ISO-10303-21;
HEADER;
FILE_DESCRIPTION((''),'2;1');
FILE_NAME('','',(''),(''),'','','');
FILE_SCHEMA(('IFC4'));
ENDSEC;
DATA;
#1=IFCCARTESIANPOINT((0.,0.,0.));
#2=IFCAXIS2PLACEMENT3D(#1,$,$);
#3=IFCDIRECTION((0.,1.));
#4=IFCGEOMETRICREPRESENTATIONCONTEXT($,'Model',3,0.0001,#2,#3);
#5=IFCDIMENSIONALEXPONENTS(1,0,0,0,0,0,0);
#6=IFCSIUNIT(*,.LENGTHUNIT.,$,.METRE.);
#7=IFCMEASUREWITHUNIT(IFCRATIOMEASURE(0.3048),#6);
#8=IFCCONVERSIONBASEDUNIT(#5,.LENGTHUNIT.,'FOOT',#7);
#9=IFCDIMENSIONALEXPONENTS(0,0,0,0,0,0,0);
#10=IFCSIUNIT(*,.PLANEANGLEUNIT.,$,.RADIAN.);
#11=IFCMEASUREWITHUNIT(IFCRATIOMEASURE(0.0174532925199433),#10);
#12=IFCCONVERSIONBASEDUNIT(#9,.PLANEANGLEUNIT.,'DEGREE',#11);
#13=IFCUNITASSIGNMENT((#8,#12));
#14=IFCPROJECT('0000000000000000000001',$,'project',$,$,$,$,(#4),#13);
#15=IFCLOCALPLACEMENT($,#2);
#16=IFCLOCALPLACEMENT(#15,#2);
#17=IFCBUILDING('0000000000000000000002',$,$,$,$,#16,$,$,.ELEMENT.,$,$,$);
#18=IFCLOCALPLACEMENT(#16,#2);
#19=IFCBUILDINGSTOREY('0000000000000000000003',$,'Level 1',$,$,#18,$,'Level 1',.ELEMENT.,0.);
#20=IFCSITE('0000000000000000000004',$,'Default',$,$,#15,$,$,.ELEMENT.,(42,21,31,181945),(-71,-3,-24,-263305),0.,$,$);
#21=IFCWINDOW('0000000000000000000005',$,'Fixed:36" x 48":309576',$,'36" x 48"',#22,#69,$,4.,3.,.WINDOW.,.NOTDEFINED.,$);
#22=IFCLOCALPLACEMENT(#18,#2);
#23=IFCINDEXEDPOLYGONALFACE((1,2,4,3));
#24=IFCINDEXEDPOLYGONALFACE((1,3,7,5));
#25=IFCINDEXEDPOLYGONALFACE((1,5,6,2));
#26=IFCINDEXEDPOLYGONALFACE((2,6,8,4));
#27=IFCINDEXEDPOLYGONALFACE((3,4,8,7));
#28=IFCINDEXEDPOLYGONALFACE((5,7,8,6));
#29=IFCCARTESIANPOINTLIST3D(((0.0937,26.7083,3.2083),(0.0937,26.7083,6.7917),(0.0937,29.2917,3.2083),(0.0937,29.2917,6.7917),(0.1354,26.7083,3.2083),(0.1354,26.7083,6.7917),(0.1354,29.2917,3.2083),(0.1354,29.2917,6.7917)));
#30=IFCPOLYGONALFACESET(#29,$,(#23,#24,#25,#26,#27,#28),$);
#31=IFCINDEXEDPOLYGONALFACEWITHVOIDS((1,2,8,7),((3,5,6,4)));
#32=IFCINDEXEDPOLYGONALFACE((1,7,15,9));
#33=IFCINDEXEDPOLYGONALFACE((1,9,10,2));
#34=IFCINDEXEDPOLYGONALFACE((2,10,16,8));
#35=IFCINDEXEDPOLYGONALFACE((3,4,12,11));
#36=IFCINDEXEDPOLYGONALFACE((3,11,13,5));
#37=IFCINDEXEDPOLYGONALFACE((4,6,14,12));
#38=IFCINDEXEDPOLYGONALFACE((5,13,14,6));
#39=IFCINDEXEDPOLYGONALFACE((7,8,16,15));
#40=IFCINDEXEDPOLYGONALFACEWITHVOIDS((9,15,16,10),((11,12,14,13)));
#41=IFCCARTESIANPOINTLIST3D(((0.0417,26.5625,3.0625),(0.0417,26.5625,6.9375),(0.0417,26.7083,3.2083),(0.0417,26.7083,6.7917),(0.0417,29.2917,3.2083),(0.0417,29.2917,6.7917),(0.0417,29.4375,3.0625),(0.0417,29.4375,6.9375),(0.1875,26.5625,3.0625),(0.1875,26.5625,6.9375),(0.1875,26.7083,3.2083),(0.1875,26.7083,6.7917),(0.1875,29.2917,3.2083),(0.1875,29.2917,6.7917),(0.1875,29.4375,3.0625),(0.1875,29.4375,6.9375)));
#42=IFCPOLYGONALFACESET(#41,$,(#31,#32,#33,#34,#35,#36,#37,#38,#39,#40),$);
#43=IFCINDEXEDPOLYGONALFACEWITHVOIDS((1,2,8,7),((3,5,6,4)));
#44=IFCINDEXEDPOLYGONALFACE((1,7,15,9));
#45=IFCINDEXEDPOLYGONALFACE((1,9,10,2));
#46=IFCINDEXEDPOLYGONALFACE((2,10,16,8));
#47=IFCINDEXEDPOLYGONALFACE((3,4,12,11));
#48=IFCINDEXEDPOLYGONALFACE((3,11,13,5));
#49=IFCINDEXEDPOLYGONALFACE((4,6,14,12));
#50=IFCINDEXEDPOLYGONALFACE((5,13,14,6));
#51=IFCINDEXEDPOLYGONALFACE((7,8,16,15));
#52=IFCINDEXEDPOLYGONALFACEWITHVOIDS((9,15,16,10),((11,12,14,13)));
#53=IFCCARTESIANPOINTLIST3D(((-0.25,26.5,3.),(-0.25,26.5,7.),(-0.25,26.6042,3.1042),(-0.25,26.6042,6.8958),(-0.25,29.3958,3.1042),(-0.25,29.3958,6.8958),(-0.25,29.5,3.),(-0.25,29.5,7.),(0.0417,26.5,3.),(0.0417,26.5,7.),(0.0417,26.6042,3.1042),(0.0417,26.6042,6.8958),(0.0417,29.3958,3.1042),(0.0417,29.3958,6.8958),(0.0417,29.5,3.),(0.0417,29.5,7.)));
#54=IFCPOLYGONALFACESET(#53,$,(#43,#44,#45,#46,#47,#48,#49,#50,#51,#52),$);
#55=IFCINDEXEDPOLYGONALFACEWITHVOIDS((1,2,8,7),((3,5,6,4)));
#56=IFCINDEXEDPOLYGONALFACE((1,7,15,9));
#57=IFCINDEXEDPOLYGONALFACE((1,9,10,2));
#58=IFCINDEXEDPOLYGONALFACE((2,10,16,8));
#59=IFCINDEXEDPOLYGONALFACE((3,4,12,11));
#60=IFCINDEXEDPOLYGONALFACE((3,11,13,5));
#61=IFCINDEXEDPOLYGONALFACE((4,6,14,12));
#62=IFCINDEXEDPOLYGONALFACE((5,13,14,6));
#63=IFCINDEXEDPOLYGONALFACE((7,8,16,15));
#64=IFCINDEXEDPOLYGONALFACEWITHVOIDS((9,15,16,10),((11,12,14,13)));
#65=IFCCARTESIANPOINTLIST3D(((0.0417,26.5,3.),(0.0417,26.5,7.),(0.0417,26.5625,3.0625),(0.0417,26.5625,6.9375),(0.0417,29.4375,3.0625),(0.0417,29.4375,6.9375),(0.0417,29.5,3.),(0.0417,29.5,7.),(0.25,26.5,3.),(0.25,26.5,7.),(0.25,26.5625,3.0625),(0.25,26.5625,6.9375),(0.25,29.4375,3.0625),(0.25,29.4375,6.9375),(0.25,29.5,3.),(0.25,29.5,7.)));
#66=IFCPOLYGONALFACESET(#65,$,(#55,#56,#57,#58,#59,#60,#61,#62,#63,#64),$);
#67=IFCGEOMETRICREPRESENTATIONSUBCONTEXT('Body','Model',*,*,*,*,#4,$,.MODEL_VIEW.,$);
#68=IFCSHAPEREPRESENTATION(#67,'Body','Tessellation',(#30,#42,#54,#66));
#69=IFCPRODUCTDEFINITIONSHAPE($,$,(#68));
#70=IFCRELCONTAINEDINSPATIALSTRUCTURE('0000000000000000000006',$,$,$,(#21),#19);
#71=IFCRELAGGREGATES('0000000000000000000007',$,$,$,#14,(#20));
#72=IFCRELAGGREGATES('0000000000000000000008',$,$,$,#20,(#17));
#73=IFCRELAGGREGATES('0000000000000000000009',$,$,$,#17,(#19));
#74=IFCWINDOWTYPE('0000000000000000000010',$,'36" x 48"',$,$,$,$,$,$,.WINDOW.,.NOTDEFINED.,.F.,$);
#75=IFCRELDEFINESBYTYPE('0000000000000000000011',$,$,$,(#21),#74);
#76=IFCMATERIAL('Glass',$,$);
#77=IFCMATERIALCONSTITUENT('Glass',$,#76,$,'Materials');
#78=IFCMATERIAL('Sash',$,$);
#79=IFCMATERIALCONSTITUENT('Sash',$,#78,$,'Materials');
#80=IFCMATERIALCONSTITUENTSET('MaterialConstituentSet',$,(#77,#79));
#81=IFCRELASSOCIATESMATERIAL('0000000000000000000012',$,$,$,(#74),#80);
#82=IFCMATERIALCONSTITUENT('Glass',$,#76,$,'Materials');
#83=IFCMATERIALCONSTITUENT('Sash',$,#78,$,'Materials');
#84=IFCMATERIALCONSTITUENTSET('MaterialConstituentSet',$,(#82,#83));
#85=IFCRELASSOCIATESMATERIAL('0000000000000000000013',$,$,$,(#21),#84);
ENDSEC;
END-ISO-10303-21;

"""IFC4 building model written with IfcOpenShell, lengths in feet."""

from ifc_helpers import new_model, entity, si_unit, converted_unit, direction, frame, frame_2d, origin, place, context, subcontext, project, spatial, polyline, rectangle, outline, extrude, source, transform, mapped, material, constituent, constituent_set, type_object, type_shapes, element, save


model = new_model("IFC4")

# Units and contexts
model_context = context("Model", 3, precision=0.0001, world=origin(), true_north=direction((0.0, 1.0)))
body_context = subcontext(model_context, "Body", "Model", "MODEL_VIEW")
ifc_project = project(units=[converted_unit("LENGTHUNIT", "FOOT", entity("IfcRatioMeasure", 0.3048), si_unit("LENGTHUNIT", "METRE"), dimensions=[1, 0, 0, 0, 0, 0, 0]), converted_unit("PLANEANGLEUNIT", "DEGREE", entity("IfcRatioMeasure", 0.0174532925199433), si_unit("PLANEANGLEUNIT", "RADIAN"), dimensions=[0, 0, 0, 0, 0, 0, 0])], contexts=[model_context])

# Site, building, storey
site_placement = place(None, origin())
site = spatial("IfcSite", under=ifc_project, at=site_placement, Name="Default", CompositionType="ELEMENT", RefLatitude=(42, 21, 31, 181945), RefLongitude=(-71, -3, -24, -263305), RefElevation=0.0)
building_placement = place(site_placement, origin())
building = spatial("IfcBuilding", under=site, at=building_placement, CompositionType="ELEMENT")
storey_placement = place(building_placement, origin())
storey = spatial("IfcBuildingStorey", under=building, at=storey_placement, Name="Level 1", LongName="Level 1", CompositionType="ELEMENT", Elevation=0.0)

# Window
ifc_material_1 = material(Name="Glass")
ifc_material_2 = material(Name="Sash")
ifc_constituent_1 = constituent(ifc_material_1, Name="Glass", Category="Materials")
ifc_constituent_2 = constituent(ifc_material_2, Name="Sash", Category="Materials")
ifc_constituent_set_1 = constituent_set(constituents=[ifc_constituent_1, ifc_constituent_2], Name="MaterialConstituentSet")
window_type = type_object("IfcWindowType", Name="36\" x 48\"", ParameterTakesPrecedence=False, PartitioningType="NOTDEFINED", PredefinedType="WINDOW", material=ifc_constituent_set_1)
shared_shape_1 = source(origin(), body_context, "Body", "SweptSolid", [
    extrude(rectangle(XDim=0.0417, YDim=2.5833, at=frame_2d((0.0, 0.0), x_axis=(1.0, 0.0))), frame((1.5, 0.3646, 0.2083), z_axis=(0.0, 0.0, 1.0), x_axis=(0.0, 1.0, 0.0)), (0.0, 0.0, 1.0), 3.5833),
    extrude(outline(polyline([(-1.4375, -1.9375), (1.4375, -1.9375), (1.4375, 1.9375), (-1.4375, 1.9375), (-1.4375, -1.9375)]), holes=[polyline([(-1.2917, -1.7917), (-1.2917, 1.7917), (1.2917, 1.7917), (1.2917, -1.7917), (-1.2917, -1.7917)])]), frame((1.5, 0.2917, 2.0), z_axis=(0.0, 1.0, 0.0), x_axis=(1.0, 0.0, 0.0)), (0.0, 0.0, 1.0), 0.1458),
    extrude(outline(polyline([(-1.5, -2.0), (1.5, -2.0), (1.5, 2.0), (-1.5, 2.0), (-1.5, -2.0)]), holes=[polyline([(-1.3958, -1.8958), (-1.3958, 1.8958), (1.3958, 1.8958), (1.3958, -1.8958), (-1.3958, -1.8958)])]), frame((1.5, 0.0, 2.0), z_axis=(0.0, 1.0, 0.0), x_axis=(1.0, 0.0, 0.0)), (0.0, 0.0, 1.0), 0.2917),
    extrude(outline(polyline([(-2.0, -1.5), (2.0, -1.5), (2.0, 1.5), (-2.0, 1.5), (-2.0, -1.5)]), holes=[polyline([(-1.9375, -1.4375), (-1.9375, 1.4375), (1.9375, 1.4375), (1.9375, -1.4375), (-1.9375, -1.4375)])]), frame((1.5, 0.2917, 2.0), z_axis=(0.0, 1.0, 0.0), x_axis=(0.0, 0.0, -1.0)), (0.0, 0.0, 1.0), 0.2083),
])
type_shapes(window_type, [shared_shape_1])
placement_1 = place(storey_placement, frame((0.0, -0.25, 0.0), z_axis=(0.0, 0.0, 1.0), x_axis=(0.0, 1.0, 0.0)))
ifc_constituent_3 = constituent(ifc_material_1, Name="Glass", Category="Materials")
ifc_constituent_4 = constituent(ifc_material_2, Name="Sash", Category="Materials")
ifc_constituent_set_2 = constituent_set(constituents=[ifc_constituent_3, ifc_constituent_4], Name="MaterialConstituentSet")
placement_2 = place(placement_1, frame((29.75, 0.25, 3.0)))
window_1_placement = place(placement_2, frame((0.0, 0.0, 0.0), z_axis=(0.0, 0.0, 1.0), x_axis=(-1.0, 0.0, 0.0)))
element("IfcWindow", 1, at=window_1_placement, inside=storey, type_object=window_type, material=ifc_constituent_set_2, Name="Fixed:36\" x 48\":309576", ObjectType="36\" x 48\"", OverallHeight=4.0, OverallWidth=3.0, PartitioningType="NOTDEFINED", PredefinedType="WINDOW", context=body_context, shape_type="MappedRepresentation", body=[
    mapped(shared_shape_1, transform((0.0, 0.0, 0.0), scale=1.0)),
])

save(model, "model.ifc")
